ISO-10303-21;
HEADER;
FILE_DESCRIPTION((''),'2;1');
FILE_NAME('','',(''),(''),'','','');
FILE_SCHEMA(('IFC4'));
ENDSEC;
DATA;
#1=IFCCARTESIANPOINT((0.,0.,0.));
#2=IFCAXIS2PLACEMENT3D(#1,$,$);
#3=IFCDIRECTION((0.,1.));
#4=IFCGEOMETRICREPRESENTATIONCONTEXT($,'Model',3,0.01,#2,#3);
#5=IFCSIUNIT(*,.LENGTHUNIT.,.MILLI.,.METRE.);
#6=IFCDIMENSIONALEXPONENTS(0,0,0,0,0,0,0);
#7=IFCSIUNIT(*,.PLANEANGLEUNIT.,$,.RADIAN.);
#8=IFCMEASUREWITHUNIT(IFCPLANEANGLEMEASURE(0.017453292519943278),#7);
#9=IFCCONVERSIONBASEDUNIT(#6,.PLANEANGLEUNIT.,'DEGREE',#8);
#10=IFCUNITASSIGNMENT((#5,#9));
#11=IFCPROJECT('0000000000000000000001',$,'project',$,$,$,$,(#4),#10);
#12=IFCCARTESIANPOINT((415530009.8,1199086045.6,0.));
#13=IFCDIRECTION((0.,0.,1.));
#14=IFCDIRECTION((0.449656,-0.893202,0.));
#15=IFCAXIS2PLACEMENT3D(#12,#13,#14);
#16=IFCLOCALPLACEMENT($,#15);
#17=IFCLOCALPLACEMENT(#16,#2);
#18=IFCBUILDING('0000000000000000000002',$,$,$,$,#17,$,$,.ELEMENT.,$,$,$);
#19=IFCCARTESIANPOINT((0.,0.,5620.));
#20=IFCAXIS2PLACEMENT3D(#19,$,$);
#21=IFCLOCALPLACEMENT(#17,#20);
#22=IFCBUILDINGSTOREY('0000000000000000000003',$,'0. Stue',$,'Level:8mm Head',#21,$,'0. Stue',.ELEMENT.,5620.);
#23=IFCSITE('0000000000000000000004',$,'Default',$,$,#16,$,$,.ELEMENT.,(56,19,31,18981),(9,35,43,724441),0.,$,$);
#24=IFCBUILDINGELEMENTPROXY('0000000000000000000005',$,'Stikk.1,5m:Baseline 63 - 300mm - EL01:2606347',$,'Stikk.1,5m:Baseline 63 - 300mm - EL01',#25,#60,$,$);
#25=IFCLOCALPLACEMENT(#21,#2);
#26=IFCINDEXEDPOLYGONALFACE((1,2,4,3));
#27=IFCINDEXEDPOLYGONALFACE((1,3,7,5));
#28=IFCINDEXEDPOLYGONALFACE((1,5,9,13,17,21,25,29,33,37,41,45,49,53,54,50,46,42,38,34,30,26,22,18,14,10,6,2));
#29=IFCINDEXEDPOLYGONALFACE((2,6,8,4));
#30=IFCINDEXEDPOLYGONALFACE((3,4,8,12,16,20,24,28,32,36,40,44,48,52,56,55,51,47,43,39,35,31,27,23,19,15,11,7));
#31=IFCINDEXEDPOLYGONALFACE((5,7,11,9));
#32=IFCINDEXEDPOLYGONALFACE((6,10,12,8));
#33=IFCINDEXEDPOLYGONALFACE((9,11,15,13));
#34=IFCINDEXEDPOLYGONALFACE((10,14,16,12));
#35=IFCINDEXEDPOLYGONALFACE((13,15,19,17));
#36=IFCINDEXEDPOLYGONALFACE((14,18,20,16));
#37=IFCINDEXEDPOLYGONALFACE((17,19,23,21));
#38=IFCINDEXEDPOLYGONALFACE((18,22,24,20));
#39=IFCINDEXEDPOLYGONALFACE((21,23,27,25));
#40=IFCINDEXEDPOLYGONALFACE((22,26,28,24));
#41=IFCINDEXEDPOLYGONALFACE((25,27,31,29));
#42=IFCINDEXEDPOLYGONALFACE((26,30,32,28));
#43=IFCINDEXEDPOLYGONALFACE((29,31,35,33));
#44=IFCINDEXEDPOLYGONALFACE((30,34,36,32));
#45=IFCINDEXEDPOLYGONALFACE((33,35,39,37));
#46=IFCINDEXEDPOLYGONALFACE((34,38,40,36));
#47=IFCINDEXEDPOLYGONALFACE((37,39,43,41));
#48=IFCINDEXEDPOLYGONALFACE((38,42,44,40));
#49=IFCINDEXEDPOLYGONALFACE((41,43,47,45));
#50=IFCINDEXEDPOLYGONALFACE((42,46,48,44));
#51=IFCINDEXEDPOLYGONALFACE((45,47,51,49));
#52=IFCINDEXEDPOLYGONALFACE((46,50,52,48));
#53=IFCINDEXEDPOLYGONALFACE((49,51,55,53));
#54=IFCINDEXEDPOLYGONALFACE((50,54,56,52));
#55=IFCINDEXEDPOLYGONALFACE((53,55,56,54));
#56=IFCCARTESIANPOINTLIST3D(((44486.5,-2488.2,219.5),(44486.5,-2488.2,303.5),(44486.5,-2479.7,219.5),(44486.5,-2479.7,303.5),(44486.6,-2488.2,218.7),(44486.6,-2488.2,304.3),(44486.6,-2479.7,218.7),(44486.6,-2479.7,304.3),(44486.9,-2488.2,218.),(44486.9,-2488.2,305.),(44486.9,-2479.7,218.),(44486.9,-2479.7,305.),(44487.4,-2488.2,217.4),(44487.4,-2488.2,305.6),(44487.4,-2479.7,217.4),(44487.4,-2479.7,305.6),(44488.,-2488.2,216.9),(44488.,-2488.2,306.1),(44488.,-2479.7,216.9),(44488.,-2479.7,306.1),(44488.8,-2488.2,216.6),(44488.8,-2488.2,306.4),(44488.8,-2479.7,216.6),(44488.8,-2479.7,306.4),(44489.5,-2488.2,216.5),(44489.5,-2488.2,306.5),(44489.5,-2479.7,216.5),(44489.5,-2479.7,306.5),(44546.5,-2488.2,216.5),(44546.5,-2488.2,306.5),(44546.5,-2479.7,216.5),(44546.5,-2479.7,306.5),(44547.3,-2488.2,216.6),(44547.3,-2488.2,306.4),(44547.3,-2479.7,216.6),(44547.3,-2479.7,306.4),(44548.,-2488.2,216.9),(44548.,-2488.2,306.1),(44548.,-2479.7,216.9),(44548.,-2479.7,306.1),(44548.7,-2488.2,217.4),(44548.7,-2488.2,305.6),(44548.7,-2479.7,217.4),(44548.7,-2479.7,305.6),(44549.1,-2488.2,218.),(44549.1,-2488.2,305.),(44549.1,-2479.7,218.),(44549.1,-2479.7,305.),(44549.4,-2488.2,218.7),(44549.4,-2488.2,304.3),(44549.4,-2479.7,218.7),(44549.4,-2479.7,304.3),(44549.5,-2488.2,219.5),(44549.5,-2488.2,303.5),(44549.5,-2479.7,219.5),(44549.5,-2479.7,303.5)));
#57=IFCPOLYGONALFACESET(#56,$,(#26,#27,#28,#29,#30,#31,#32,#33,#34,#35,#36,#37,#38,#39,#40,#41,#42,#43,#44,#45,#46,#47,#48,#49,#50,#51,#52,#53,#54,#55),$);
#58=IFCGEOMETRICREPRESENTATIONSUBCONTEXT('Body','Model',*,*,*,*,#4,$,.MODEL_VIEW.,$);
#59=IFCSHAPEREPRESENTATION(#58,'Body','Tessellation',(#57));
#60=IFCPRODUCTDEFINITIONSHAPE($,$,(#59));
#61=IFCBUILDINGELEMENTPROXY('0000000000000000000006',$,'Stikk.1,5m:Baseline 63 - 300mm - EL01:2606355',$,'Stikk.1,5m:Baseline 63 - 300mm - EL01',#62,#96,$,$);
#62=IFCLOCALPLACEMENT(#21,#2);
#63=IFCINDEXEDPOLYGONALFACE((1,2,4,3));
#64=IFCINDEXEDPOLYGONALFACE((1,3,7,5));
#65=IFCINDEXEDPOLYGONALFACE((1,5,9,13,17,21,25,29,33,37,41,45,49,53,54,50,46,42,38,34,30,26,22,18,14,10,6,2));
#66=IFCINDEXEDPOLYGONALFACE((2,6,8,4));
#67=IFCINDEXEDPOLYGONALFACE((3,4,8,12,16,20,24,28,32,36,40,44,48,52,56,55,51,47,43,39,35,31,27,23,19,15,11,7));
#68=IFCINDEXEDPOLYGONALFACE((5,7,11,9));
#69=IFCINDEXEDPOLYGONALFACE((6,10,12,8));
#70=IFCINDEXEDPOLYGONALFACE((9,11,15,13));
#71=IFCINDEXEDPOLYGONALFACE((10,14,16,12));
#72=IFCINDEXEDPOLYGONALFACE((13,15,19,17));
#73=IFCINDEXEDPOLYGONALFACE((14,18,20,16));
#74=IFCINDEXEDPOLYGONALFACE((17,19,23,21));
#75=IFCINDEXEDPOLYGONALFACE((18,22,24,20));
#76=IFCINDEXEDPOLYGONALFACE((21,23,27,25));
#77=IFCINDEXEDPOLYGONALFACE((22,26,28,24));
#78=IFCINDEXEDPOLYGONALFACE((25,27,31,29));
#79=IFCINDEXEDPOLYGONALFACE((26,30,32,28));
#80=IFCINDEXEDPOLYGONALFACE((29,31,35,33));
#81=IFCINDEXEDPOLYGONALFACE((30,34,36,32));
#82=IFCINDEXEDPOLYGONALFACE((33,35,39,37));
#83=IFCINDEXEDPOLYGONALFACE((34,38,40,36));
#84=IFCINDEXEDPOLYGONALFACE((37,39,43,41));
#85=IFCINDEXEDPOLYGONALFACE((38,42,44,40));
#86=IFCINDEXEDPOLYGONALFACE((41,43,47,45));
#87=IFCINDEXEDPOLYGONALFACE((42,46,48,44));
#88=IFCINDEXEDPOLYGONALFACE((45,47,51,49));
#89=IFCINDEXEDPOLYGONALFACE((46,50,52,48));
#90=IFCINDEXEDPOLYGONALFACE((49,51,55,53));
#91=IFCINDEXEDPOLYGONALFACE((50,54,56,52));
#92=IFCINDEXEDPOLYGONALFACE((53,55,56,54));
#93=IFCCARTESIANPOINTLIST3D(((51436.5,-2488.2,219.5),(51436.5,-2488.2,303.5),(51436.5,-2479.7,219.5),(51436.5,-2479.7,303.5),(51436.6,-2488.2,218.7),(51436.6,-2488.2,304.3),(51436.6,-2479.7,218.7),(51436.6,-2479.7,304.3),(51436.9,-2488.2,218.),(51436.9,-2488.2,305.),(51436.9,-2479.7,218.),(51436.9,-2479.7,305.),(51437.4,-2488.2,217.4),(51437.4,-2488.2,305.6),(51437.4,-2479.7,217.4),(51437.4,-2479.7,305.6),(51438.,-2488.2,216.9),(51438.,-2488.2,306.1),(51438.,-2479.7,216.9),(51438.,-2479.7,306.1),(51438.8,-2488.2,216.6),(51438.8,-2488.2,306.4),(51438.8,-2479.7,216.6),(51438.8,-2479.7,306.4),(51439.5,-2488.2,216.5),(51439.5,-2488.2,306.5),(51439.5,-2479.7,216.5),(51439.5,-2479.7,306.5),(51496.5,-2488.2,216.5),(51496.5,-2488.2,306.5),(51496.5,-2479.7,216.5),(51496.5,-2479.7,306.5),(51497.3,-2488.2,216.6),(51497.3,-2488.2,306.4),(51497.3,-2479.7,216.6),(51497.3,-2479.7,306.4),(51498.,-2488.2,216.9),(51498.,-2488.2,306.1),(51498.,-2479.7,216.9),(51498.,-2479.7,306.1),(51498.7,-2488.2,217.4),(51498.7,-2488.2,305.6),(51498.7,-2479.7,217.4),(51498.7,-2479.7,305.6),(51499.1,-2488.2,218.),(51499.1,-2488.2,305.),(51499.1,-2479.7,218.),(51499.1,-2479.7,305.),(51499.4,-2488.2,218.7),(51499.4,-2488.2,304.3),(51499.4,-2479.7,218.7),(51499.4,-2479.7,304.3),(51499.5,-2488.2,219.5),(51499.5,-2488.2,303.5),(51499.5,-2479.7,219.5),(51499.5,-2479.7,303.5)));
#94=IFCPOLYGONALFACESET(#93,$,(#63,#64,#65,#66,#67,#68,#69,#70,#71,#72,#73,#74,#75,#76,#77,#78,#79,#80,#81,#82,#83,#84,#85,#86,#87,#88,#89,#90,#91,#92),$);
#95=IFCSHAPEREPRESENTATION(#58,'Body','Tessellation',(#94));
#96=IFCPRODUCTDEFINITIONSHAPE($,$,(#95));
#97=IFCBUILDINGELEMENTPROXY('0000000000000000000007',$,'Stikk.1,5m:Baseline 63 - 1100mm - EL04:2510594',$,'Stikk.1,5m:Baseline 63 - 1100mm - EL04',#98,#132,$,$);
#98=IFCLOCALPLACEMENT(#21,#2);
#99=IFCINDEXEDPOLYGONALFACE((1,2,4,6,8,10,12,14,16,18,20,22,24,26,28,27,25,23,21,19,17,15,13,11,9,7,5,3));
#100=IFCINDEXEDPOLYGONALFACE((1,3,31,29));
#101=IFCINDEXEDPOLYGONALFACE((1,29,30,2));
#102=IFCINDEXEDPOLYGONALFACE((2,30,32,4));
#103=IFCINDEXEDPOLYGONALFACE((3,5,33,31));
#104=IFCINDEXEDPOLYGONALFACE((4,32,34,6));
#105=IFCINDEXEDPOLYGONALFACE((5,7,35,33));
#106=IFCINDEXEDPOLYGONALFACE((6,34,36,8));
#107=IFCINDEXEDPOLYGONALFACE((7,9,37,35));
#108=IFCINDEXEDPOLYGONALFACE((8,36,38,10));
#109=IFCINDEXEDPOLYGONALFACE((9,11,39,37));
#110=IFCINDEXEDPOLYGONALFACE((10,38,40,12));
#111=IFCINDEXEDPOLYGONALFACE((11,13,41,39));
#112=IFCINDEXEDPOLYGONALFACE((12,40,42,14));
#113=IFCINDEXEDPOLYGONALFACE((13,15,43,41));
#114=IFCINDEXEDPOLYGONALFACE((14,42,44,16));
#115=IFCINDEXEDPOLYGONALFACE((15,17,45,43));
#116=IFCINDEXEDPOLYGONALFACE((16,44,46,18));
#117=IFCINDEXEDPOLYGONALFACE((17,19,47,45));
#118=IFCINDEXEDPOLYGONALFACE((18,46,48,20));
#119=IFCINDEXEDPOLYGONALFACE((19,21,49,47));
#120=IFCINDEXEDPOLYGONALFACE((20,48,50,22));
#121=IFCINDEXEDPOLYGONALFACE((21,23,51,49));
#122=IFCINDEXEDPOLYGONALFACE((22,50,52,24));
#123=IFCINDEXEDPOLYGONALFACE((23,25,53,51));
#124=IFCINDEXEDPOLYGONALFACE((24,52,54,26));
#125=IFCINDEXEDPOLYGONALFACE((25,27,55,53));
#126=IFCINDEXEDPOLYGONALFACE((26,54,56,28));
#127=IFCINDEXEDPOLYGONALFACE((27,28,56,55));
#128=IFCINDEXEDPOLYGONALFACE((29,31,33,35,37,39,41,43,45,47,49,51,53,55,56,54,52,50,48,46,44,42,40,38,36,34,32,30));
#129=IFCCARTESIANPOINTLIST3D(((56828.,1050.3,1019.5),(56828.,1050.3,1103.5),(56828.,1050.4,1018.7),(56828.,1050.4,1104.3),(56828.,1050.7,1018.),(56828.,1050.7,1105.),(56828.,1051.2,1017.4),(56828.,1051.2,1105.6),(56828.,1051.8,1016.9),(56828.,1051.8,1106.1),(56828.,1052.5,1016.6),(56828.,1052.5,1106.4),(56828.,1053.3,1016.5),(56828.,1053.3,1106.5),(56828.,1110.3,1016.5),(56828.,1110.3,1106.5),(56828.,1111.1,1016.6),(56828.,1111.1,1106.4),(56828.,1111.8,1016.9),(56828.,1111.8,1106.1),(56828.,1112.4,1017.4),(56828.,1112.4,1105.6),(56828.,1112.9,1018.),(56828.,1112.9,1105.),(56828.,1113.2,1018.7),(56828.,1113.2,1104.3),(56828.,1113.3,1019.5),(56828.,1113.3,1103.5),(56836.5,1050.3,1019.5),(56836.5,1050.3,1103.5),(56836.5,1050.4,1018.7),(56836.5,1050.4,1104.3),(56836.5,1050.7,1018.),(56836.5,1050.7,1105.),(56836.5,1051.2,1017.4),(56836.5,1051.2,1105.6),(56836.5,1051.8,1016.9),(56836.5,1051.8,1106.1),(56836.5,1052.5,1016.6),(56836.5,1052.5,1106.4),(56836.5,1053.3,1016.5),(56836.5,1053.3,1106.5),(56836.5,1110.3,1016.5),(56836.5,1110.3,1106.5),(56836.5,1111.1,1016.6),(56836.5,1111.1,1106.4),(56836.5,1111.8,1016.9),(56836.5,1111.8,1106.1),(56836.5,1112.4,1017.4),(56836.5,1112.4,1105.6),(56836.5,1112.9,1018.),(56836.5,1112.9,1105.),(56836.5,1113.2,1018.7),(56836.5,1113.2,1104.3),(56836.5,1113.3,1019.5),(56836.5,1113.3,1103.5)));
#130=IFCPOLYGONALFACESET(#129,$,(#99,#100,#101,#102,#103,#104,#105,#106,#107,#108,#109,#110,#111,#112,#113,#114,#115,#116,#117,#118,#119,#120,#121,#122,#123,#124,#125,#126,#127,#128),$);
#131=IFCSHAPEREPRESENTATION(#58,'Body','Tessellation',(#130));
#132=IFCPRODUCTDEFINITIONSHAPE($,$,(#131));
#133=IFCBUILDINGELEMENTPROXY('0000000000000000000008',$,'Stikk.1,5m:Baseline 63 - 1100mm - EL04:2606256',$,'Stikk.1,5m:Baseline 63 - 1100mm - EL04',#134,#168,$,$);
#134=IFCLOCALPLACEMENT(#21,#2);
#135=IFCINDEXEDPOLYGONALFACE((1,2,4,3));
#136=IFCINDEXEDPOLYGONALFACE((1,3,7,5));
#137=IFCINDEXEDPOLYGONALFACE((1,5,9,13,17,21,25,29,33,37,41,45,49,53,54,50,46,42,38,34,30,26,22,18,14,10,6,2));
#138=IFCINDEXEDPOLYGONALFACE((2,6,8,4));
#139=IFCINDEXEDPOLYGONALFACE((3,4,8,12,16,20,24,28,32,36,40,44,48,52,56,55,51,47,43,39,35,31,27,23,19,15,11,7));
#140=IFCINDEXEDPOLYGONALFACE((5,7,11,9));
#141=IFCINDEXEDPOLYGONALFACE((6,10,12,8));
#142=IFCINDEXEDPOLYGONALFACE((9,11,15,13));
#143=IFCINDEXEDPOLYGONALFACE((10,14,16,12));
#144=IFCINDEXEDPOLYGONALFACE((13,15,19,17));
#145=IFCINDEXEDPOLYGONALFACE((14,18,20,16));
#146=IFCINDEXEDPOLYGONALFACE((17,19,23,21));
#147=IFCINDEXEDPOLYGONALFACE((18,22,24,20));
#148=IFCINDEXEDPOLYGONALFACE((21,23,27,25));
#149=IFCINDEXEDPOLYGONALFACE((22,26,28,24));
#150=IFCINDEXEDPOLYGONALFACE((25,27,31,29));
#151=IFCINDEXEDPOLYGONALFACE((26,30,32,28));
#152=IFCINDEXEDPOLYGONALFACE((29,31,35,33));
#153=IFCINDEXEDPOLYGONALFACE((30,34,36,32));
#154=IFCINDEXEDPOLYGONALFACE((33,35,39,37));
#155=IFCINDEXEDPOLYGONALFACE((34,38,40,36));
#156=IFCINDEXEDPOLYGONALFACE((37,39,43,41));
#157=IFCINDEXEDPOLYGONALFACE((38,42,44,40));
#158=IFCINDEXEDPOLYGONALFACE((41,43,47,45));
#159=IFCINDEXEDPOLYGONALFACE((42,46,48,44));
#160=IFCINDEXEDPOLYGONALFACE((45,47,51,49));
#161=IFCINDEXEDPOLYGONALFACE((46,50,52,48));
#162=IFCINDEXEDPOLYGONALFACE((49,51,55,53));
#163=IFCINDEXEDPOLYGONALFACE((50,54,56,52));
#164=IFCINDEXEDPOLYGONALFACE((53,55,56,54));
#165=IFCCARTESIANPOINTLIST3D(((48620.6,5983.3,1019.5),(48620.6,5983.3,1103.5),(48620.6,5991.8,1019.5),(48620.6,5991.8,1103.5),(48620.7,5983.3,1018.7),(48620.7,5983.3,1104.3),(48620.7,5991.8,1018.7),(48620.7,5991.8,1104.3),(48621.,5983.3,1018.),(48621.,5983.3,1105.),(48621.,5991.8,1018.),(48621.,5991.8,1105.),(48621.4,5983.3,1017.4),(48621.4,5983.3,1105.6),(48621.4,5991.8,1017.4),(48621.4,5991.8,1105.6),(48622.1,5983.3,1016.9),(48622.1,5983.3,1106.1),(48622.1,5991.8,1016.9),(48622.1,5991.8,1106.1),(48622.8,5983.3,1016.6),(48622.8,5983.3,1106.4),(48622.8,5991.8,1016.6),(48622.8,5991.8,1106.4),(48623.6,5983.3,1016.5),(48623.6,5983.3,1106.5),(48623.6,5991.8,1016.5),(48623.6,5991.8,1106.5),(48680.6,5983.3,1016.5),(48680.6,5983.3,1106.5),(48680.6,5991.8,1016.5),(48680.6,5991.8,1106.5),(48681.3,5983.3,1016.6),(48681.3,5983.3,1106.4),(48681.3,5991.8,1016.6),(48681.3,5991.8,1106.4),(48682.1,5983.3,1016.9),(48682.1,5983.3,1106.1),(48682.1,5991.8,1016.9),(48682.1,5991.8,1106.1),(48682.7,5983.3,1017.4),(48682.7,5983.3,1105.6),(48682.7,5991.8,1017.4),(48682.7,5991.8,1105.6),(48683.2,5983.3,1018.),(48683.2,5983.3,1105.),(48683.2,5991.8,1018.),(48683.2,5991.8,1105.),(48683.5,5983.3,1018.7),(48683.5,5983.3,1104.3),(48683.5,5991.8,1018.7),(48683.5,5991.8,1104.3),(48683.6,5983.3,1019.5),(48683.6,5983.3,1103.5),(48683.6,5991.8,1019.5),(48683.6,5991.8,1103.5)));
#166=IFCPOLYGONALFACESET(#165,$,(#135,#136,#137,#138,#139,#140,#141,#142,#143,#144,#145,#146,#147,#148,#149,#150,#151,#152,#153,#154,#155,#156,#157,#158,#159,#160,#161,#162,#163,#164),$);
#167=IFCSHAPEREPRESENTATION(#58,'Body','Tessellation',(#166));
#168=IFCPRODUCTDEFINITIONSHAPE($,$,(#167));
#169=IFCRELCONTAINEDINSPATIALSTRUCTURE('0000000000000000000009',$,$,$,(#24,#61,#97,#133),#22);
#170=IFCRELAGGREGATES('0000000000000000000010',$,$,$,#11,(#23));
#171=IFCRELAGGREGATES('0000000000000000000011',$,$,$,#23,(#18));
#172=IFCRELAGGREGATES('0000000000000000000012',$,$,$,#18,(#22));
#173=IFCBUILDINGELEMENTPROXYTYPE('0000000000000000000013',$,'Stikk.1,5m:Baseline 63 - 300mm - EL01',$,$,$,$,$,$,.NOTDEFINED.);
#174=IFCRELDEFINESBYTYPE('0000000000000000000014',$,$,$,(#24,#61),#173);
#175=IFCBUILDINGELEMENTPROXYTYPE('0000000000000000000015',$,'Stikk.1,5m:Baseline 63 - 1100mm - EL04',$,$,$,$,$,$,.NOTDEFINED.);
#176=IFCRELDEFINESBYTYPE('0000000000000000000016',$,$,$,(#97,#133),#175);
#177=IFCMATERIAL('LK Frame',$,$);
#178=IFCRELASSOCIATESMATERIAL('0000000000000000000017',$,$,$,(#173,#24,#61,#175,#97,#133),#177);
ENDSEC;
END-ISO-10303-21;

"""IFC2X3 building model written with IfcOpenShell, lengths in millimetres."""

from ifc_helpers import new_model, entity, si_unit, converted_unit, direction, frame, frame_2d, origin, place, context, subcontext, project, spatial, polyline, circle_curve, parameter, trimmed, segment, composite_curve, outline, extrude, source, transform, mapped, material, type_object, type_shapes, element, save


model = new_model("IFC2X3")

# Units and contexts
model_context = context("Model", 3, precision=0.01, world=origin(), true_north=direction((0.0, 1.0)))
body_context = subcontext(model_context, "Body", "Model", "MODEL_VIEW")
ifc_project = project(units=[si_unit("LENGTHUNIT", "METRE", prefix="MILLI"), converted_unit("PLANEANGLEUNIT", "DEGREE", entity("IfcPlaneAngleMeasure", 0.017453292519943278), si_unit("PLANEANGLEUNIT", "RADIAN"), dimensions=[0, 0, 0, 0, 0, 0, 0])], contexts=[model_context])

# Site, building, storey
site_placement = place(None, frame((415530009.8, 1199086045.6, 0.0), z_axis=(0.0, 0.0, 1.0), x_axis=(0.449656, -0.893202, 0.0)))
site = spatial("IfcSite", under=ifc_project, at=site_placement, Name="Default", CompositionType="ELEMENT", RefLatitude=(56, 19, 31, 18981), RefLongitude=(9, 35, 43, 724441), RefElevation=0.0)
building_placement = place(site_placement, origin())
building = spatial("IfcBuilding", under=site, at=building_placement, CompositionType="ELEMENT")
storey_placement = place(building_placement, frame((0.0, 0.0, 5620.0)))
storey = spatial("IfcBuildingStorey", under=building, at=storey_placement, Name="0. Stue", ObjectType="Level:8mm Head", LongName="0. Stue", CompositionType="ELEMENT", Elevation=5620.0)

# Building element proxies
ifc_material_1 = material(Name="LK Frame")
building_element_proxy_type_1 = type_object("IfcBuildingElementProxyType", Name="Stikk.1,5m:Baseline 63 - 300mm - EL01", PredefinedType="NOTDEFINED", material=ifc_material_1)
shared_shape_1 = source(origin(), body_context, "Body", "SweptSolid", [
    extrude(outline(composite_curve([segment(polyline([(-42.0, -31.5), (42.0, -31.5)]), True, "CONTINUOUS"), segment(trimmed(circle_curve(frame_2d((42.0, -28.5), x_axis=(-1.0, 0.0)), 3.0), [parameter(90.0)], [parameter(180.0)], True, "PARAMETER"), True, "CONTINUOUS"), segment(polyline([(45.0, -28.5), (45.0, 28.5)]), True, "CONTINUOUS"), segment(trimmed(circle_curve(frame_2d((42.0, 28.5), x_axis=(-1.0, 0.0)), 3.0), [parameter(180.0)], [parameter(270.0)], True, "PARAMETER"), True, "CONTINUOUS"), segment(polyline([(42.0, 31.5), (-42.0, 31.5)]), True, "CONTINUOUS"), segment(trimmed(circle_curve(frame_2d((-42.0, 28.5), x_axis=(1.0, 0.0)), 3.0), [parameter(90.0)], [parameter(180.0)], True, "PARAMETER"), True, "CONTINUOUS"), segment(polyline([(-45.0, 28.5), (-45.0, -28.5)]), True, "CONTINUOUS"), segment(trimmed(circle_curve(frame_2d((-42.0, -28.5), x_axis=(1.0, 0.0)), 3.0), [parameter(180.0)], [parameter(270.0)], True, "PARAMETER"), True, "CONTINUOUS")], self_intersect=False)), frame((0.0, -38.5, 0.0), z_axis=(0.0, 0.0, 1.0), x_axis=(0.0, 1.0, 0.0)), (0.0, 0.0, 1.0), 8.5),
])
type_shapes(building_element_proxy_type_1, [shared_shape_1])
for number, where, z_axis, x_axis, name in (
    (1, (44518.0, -2488.2, 300.0), (0.0, 1.0, 0.0), (-1.0, 0.0, 0.0), "Stikk.1,5m:Baseline 63 - 300mm - EL01:2606347"),
    (2, (51468.0, -2488.2, 300.0), (0.0, 1.0, 0.0), (-1.0, 0.0, 0.0), "Stikk.1,5m:Baseline 63 - 300mm - EL01:2606355"),
):
    element("IfcBuildingElementProxy", number, at=place(storey_placement, frame(where, z_axis=z_axis, x_axis=x_axis)), inside=storey, type_object=building_element_proxy_type_1, material=ifc_material_1, Name=name, ObjectType="Stikk.1,5m:Baseline 63 - 300mm - EL01", context=body_context, shape_type="MappedRepresentation", body=[
        mapped(shared_shape_1, transform((0.0, 0.0, 0.0), scale=1.0)),
    ])
building_element_proxy_type_2 = type_object("IfcBuildingElementProxyType", Name="Stikk.1,5m:Baseline 63 - 1100mm - EL04", PredefinedType="NOTDEFINED", material=ifc_material_1)
shared_shape_2 = source(origin(), body_context, "Body", "SweptSolid", [
    extrude(outline(composite_curve([segment(polyline([(-42.0, -31.5), (42.0, -31.5)]), True, "CONTINUOUS"), segment(trimmed(circle_curve(frame_2d((42.0, -28.5), x_axis=(-1.0, 0.0)), 3.0), [parameter(90.0)], [parameter(180.0)], True, "PARAMETER"), True, "CONTINUOUS"), segment(polyline([(45.0, -28.5), (45.0, 28.5)]), True, "CONTINUOUS"), segment(trimmed(circle_curve(frame_2d((42.0, 28.5), x_axis=(-1.0, 0.0)), 3.0), [parameter(180.0)], [parameter(270.0)], True, "PARAMETER"), True, "CONTINUOUS"), segment(polyline([(42.0, 31.5), (-42.0, 31.5)]), True, "CONTINUOUS"), segment(trimmed(circle_curve(frame_2d((-42.0, 28.5), x_axis=(1.0, 0.0)), 3.0), [parameter(90.0)], [parameter(180.0)], True, "PARAMETER"), True, "CONTINUOUS"), segment(polyline([(-45.0, 28.5), (-45.0, -28.5)]), True, "CONTINUOUS"), segment(trimmed(circle_curve(frame_2d((-42.0, -28.5), x_axis=(1.0, 0.0)), 3.0), [parameter(180.0)], [parameter(270.0)], True, "PARAMETER"), True, "CONTINUOUS")], self_intersect=False)), frame((0.0, -38.5, 0.0), z_axis=(0.0, 0.0, 1.0), x_axis=(0.0, 1.0, 0.0)), (0.0, 0.0, 1.0), 8.5),
])
type_shapes(building_element_proxy_type_2, [shared_shape_2])
for number, where, z_axis, x_axis, name in (
    (3, (56828.0, 1081.8, 1100.0), (1.0, 0.0, 0.0), (0.0, 1.0, 0.0), "Stikk.1,5m:Baseline 63 - 1100mm - EL04:2510594"),
    (4, (48652.1, 5991.8, 1100.0), (0.0, -1.0, 0.0), (1.0, 0.0, 0.0), "Stikk.1,5m:Baseline 63 - 1100mm - EL04:2606256"),
):
    element("IfcBuildingElementProxy", number, at=place(storey_placement, frame(where, z_axis=z_axis, x_axis=x_axis)), inside=storey, type_object=building_element_proxy_type_2, material=ifc_material_1, Name=name, ObjectType="Stikk.1,5m:Baseline 63 - 1100mm - EL04", context=body_context, shape_type="MappedRepresentation", body=[
        mapped(shared_shape_2, transform((0.0, 0.0, 0.0), scale=1.0)),
    ])

save(model, "model.ifc")
